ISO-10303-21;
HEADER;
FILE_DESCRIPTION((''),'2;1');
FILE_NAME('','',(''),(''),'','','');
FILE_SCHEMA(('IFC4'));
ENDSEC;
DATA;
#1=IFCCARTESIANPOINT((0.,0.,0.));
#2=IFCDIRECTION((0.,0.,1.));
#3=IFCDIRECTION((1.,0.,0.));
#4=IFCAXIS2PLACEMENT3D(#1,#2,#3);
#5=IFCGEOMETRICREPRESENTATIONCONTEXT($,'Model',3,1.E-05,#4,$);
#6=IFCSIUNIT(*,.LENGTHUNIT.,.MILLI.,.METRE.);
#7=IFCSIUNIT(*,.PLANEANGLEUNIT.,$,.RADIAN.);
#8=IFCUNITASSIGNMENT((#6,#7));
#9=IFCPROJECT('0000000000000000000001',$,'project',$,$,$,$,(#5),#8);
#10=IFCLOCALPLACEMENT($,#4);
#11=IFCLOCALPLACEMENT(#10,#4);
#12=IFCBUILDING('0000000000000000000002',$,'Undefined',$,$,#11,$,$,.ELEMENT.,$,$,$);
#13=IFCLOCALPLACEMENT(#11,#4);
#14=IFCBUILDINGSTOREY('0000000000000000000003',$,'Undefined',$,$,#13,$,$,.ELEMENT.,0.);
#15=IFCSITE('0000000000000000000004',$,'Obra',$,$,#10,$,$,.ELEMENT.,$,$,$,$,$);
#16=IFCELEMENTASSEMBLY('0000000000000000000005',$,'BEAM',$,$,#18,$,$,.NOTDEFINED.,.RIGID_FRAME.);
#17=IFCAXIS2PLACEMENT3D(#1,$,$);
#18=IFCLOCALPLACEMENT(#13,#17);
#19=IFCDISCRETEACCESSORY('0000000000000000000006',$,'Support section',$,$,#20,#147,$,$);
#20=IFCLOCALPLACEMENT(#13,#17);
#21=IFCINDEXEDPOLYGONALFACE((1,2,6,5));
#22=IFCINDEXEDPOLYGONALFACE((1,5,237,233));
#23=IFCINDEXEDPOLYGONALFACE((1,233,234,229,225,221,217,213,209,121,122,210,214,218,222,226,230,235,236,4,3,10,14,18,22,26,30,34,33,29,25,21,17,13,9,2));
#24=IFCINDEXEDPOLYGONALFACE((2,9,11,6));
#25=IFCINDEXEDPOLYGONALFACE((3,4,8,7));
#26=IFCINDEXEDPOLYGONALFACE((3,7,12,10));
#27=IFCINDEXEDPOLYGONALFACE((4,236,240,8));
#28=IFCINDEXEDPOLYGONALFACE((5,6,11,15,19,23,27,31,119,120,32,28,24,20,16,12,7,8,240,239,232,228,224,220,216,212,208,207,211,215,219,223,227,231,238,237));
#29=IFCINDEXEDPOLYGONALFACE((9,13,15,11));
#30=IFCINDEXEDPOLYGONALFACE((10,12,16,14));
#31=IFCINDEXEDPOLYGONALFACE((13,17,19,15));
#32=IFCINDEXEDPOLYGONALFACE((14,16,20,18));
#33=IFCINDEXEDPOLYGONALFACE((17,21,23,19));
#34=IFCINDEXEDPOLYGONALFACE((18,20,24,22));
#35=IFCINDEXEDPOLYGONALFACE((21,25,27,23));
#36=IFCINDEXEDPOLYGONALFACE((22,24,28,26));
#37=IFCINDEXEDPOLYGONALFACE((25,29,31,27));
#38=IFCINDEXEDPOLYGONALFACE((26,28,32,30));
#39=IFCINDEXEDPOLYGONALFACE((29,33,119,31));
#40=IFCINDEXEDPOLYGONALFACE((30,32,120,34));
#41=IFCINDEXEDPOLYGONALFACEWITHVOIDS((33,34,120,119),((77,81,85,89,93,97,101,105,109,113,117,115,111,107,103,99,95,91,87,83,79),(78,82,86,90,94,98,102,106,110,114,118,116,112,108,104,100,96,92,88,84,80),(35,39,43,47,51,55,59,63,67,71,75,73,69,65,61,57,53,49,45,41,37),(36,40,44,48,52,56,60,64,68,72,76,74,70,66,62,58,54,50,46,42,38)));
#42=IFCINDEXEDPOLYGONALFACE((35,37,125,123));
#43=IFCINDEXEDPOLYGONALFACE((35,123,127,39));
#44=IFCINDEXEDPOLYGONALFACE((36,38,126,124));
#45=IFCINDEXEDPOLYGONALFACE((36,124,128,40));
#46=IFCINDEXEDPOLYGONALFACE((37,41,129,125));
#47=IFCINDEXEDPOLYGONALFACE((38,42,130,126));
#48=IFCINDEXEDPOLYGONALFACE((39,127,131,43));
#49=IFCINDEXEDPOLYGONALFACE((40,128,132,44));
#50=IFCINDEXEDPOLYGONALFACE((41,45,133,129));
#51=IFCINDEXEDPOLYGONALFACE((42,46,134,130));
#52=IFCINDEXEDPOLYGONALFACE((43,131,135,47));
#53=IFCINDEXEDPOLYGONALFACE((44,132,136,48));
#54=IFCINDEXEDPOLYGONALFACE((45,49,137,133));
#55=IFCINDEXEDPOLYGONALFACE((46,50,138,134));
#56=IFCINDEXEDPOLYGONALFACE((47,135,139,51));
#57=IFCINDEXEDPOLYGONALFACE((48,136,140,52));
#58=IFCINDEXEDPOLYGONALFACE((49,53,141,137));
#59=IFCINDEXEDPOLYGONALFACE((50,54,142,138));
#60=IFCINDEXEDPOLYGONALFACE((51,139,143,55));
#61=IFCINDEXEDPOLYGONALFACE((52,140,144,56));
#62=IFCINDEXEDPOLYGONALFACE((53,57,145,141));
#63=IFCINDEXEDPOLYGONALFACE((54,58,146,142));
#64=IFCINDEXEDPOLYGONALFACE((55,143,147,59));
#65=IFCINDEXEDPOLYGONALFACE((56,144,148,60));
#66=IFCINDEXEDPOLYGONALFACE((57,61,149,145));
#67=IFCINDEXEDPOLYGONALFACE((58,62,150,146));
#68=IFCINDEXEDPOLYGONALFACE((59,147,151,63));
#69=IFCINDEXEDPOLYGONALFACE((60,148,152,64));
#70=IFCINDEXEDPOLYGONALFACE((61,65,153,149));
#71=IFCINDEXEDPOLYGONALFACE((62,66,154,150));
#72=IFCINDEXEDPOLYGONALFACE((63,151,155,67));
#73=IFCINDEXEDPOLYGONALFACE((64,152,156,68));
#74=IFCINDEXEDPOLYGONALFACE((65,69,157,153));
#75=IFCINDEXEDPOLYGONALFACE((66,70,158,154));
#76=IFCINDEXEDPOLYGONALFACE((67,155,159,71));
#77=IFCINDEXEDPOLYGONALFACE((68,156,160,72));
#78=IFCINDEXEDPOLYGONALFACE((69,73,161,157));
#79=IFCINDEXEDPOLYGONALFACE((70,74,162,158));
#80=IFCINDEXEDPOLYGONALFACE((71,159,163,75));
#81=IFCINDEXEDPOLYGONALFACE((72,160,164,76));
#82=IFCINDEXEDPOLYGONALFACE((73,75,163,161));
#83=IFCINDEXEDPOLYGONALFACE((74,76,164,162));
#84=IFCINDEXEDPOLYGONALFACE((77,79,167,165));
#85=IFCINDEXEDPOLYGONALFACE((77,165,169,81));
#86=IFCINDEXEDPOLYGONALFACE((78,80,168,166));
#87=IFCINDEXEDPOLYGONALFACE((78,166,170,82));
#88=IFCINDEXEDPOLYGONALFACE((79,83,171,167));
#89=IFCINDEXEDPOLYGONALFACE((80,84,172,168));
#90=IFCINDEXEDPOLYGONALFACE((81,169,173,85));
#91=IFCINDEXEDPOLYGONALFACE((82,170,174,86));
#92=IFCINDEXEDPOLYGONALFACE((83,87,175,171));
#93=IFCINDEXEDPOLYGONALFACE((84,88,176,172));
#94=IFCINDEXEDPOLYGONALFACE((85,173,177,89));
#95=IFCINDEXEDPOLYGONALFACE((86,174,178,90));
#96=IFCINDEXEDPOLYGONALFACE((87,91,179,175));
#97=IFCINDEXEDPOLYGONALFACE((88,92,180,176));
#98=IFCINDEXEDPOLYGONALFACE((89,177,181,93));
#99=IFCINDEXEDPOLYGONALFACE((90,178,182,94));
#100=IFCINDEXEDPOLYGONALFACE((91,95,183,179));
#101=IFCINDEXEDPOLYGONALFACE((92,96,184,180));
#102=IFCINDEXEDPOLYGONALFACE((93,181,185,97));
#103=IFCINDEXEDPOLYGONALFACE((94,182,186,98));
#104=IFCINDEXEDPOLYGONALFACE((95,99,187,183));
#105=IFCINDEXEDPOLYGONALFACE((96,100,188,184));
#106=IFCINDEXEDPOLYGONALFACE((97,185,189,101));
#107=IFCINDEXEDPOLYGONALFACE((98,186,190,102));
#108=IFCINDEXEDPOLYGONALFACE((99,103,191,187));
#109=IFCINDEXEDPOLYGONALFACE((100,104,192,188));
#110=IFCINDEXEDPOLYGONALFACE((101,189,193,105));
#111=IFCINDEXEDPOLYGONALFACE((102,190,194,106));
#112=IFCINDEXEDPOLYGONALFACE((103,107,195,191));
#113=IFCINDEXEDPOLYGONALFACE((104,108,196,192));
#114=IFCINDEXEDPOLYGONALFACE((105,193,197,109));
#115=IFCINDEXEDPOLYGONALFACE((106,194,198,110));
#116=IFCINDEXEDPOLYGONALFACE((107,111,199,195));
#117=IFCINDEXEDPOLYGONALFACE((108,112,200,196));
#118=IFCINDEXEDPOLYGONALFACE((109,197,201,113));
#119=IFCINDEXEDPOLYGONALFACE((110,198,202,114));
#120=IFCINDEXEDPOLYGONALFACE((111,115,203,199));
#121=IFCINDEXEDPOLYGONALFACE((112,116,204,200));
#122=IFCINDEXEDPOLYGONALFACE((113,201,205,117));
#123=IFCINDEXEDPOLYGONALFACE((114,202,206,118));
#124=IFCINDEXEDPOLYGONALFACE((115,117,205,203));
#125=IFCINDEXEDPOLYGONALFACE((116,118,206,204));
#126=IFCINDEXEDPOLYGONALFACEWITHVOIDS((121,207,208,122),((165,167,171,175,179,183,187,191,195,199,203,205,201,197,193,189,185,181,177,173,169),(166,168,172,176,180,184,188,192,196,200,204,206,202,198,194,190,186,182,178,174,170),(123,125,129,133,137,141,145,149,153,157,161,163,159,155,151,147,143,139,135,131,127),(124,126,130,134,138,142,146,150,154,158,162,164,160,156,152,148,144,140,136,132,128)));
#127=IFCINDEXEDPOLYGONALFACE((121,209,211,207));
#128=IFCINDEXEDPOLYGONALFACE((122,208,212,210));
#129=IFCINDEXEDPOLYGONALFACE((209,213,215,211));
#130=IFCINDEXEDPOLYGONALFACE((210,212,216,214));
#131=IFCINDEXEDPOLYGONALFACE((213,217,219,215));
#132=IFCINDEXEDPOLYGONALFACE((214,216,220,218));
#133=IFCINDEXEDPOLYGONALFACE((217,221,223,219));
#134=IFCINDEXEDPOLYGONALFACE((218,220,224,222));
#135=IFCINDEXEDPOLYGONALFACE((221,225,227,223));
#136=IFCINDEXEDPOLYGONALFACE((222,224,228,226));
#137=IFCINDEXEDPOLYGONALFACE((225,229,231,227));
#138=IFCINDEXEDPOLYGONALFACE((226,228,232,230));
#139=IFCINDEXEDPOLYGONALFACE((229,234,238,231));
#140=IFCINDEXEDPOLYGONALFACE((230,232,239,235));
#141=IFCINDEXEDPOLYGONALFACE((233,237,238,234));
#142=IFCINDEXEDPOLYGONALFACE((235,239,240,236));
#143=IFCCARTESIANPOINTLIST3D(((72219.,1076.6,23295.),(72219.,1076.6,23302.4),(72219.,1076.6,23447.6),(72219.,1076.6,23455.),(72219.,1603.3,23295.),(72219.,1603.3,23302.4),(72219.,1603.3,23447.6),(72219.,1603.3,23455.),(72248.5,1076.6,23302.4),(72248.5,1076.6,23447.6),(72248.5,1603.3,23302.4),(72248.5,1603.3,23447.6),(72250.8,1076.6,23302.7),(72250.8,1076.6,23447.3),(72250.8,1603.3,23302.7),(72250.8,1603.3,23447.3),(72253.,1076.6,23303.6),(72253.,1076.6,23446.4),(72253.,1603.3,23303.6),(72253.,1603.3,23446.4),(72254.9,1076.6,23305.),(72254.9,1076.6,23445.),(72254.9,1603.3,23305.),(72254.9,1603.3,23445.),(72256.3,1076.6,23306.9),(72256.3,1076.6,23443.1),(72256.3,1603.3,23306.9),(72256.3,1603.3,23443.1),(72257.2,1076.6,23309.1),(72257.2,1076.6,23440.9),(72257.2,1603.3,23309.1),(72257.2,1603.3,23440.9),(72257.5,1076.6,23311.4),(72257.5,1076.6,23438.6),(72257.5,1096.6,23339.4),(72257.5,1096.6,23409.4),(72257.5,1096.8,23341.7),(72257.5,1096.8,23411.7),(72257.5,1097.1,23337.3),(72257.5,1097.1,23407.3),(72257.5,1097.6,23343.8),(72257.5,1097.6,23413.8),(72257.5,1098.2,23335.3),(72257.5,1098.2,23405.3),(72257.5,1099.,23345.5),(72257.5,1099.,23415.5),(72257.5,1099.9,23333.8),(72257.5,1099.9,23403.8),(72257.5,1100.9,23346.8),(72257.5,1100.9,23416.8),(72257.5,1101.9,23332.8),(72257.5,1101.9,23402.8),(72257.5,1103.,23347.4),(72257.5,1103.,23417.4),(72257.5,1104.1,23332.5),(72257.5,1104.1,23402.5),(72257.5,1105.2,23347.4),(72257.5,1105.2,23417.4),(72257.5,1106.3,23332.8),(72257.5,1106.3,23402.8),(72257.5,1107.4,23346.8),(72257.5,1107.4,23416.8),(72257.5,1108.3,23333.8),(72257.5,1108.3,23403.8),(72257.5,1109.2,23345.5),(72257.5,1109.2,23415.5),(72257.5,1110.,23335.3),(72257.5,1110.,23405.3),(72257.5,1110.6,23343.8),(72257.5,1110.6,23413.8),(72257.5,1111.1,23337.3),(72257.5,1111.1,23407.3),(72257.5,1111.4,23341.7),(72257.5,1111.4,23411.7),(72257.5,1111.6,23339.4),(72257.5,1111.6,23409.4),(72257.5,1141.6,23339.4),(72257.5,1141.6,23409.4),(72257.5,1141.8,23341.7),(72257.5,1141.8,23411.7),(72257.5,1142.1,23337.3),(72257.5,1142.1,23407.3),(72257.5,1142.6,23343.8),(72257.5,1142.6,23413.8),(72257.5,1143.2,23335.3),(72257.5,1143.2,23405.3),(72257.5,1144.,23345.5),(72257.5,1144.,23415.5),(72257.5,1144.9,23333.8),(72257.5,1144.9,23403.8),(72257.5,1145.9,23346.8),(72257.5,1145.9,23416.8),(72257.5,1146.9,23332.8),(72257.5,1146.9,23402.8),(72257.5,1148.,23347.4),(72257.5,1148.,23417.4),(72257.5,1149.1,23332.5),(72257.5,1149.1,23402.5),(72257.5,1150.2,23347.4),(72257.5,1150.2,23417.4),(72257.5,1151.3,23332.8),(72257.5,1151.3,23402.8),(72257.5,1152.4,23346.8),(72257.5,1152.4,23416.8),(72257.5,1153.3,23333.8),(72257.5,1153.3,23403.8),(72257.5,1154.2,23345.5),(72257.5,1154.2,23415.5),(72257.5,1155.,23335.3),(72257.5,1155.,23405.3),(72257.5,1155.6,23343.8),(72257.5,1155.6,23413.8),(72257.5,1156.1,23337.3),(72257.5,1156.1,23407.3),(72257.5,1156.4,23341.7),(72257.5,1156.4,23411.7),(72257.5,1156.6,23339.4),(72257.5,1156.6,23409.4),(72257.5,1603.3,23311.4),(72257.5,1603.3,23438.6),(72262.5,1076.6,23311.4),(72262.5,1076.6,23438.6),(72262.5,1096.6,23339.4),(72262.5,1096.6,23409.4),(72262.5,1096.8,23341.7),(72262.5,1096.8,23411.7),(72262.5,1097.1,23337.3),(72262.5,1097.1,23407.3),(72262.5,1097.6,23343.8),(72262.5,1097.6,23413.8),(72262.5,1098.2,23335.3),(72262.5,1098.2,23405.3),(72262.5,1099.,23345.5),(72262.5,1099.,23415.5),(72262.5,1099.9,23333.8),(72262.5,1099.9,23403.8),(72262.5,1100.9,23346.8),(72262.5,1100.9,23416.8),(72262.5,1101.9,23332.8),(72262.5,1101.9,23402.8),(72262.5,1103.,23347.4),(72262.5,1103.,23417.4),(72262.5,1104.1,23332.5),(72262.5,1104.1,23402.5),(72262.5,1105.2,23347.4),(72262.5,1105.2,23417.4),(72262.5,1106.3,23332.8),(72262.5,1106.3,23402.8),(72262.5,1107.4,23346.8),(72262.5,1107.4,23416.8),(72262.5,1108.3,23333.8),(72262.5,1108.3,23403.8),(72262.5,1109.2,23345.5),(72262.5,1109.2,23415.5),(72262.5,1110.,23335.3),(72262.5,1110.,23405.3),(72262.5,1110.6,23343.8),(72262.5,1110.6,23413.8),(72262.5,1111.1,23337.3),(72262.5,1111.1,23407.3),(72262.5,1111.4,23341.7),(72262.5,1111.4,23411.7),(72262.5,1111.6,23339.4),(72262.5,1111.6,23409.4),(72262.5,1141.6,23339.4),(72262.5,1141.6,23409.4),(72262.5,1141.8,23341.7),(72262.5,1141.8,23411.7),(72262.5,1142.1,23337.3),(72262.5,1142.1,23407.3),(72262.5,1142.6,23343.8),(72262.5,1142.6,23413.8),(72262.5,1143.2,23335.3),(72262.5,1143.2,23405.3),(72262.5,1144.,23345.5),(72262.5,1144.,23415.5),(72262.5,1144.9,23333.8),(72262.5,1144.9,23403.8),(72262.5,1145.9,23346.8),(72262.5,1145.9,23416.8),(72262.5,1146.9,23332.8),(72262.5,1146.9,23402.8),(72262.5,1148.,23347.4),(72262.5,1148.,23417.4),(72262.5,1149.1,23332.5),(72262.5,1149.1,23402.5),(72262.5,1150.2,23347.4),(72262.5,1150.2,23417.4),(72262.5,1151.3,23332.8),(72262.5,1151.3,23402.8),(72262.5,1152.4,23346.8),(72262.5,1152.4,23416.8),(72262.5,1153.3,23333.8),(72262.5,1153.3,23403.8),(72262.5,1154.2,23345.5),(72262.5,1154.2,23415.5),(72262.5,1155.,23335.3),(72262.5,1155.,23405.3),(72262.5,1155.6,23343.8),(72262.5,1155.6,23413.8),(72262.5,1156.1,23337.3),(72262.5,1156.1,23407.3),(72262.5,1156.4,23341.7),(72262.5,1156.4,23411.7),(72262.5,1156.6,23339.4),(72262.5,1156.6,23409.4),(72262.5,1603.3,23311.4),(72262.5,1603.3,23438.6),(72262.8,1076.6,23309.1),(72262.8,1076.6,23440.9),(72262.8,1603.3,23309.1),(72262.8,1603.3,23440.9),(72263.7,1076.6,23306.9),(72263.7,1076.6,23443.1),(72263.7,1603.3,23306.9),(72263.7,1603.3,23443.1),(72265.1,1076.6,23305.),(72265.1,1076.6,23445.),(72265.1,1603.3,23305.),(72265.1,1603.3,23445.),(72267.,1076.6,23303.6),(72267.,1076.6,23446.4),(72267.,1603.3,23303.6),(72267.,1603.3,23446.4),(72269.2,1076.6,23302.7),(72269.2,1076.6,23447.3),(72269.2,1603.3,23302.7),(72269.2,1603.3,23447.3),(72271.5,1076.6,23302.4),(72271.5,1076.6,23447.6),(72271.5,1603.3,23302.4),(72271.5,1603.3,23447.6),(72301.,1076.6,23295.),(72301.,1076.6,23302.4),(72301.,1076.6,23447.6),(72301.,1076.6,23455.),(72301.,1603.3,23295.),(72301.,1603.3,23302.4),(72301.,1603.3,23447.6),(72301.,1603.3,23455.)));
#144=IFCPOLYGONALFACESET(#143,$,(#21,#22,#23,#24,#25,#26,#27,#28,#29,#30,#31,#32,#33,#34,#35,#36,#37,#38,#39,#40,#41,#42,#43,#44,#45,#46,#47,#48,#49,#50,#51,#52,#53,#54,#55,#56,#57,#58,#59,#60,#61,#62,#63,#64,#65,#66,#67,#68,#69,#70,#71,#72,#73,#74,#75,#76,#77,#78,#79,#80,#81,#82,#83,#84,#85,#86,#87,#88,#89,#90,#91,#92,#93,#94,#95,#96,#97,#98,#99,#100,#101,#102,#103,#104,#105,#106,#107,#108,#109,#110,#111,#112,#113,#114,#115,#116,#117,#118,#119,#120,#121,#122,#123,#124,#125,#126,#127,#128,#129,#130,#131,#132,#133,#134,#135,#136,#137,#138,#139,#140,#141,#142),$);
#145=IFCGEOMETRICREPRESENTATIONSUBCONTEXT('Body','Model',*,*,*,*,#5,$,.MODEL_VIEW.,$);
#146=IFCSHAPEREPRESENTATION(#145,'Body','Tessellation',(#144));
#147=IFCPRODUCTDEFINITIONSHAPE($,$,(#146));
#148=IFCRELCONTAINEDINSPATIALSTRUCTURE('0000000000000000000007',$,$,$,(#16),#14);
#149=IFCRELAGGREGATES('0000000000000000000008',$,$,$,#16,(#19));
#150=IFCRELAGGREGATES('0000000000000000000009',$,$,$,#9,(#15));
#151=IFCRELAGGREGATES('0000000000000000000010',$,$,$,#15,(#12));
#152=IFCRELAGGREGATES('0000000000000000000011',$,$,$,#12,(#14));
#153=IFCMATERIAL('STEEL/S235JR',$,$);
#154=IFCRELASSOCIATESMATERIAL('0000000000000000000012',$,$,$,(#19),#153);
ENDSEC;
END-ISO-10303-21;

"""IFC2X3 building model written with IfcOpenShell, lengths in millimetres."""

from ifc_helpers import new_model, si_unit, frame, origin_with_axes, origin_2d_with_axis, place, context, subcontext, project, spatial, circle, i_section, extrude, clip, halfspace, source, transform, mapped, material, element, aggregate, save


model = new_model("IFC2X3")

# Units and contexts
model_context = context("Model", 3, precision=1e-05, world=origin_with_axes())
body_context = subcontext(model_context, "Body", "Model", "MODEL_VIEW")
ifc_project = project(units=[si_unit("LENGTHUNIT", "METRE", prefix="MILLI"), si_unit("PLANEANGLEUNIT", "RADIAN")], contexts=[model_context])

# Site, building, storey
site_placement = place(None, origin_with_axes())
site = spatial("IfcSite", under=ifc_project, at=site_placement, Name="Obra", CompositionType="ELEMENT")
building_placement = place(site_placement, origin_with_axes())
building = spatial("IfcBuilding", under=site, at=building_placement, Name="Undefined", CompositionType="ELEMENT")
storey_placement = place(building_placement, origin_with_axes())
storey = spatial("IfcBuildingStorey", under=building, at=storey_placement, Name="Undefined", CompositionType="ELEMENT", Elevation=0.0)

# Shared definitions
ifc_material_1 = material(Name="STEEL/S235JR")

# Element assembly
assembly_1_placement = place(storey_placement, origin_with_axes())
assembly_1 = element("IfcElementAssembly", 1, at=assembly_1_placement, inside=storey, Name="BEAM", AssemblyPlace="NOTDEFINED", PredefinedType="RIGID_FRAME")

# Discrete accessory, opening
discrete_accessory_1_placement = place(assembly_1_placement, frame((72260.0, 1086.6, 23375.0), z_axis=(0.0, 0.0, 1.0), x_axis=(0.0, 1.0, 0.0)))
discrete_accessory_1 = element("IfcDiscreteAccessory", 2, at=discrete_accessory_1_placement, material=ifc_material_1, Name="Support section", context=body_context, shape_type="Clipping", body=[
    clip(extrude(i_section(OverallWidth=82.0, OverallDepth=160.0, WebThickness=5.0, FlangeThickness=7.4, FilletRadius=9.0, at=origin_2d_with_axis()), frame((516.7, 0.0, 0.0), z_axis=(-1.0, 0.0, 0.0), x_axis=(0.0, -1.0, 0.0)), (0.0, 0.0, 1.0), 526.7), halfspace(frame((-10.0, 0.0, -180.0), z_axis=(1.0, 0.0, 0.0), x_axis=(0.0, -1.0, 0.0)), True)),
])
shared_shape_1 = source(origin_with_axes(), body_context, "Body", "SweptSolid", [
    extrude(circle(Radius=7.5, at=origin_2d_with_axis()), frame((0.0, -2.6, 0.0), z_axis=(0.0, 1.0, 0.0), x_axis=(1.0, 0.0, 0.0)), (0.0, 0.0, 1.0), 5.2),
])
opening_1_placement = place(assembly_1_placement, frame((72260.0, 1126.6, 23410.0), z_axis=(0.0, 1.0, 0.0), x_axis=(0.0, 0.0, -1.0)))
element("IfcOpeningElement", 3, at=opening_1_placement, cuts=discrete_accessory_1, ObjectType="Opening", context=body_context, shape_type="MappedRepresentation", body=[
    mapped(shared_shape_1, transform((0.0, 0.0, -22.5))),
    mapped(shared_shape_1, transform((70.0, 0.0, -22.5))),
    mapped(shared_shape_1, transform((0.0, 0.0, 22.5))),
    mapped(shared_shape_1, transform((70.0, 0.0, 22.5))),
])
aggregate(assembly_1, [discrete_accessory_1])

save(model, "model.ifc")
